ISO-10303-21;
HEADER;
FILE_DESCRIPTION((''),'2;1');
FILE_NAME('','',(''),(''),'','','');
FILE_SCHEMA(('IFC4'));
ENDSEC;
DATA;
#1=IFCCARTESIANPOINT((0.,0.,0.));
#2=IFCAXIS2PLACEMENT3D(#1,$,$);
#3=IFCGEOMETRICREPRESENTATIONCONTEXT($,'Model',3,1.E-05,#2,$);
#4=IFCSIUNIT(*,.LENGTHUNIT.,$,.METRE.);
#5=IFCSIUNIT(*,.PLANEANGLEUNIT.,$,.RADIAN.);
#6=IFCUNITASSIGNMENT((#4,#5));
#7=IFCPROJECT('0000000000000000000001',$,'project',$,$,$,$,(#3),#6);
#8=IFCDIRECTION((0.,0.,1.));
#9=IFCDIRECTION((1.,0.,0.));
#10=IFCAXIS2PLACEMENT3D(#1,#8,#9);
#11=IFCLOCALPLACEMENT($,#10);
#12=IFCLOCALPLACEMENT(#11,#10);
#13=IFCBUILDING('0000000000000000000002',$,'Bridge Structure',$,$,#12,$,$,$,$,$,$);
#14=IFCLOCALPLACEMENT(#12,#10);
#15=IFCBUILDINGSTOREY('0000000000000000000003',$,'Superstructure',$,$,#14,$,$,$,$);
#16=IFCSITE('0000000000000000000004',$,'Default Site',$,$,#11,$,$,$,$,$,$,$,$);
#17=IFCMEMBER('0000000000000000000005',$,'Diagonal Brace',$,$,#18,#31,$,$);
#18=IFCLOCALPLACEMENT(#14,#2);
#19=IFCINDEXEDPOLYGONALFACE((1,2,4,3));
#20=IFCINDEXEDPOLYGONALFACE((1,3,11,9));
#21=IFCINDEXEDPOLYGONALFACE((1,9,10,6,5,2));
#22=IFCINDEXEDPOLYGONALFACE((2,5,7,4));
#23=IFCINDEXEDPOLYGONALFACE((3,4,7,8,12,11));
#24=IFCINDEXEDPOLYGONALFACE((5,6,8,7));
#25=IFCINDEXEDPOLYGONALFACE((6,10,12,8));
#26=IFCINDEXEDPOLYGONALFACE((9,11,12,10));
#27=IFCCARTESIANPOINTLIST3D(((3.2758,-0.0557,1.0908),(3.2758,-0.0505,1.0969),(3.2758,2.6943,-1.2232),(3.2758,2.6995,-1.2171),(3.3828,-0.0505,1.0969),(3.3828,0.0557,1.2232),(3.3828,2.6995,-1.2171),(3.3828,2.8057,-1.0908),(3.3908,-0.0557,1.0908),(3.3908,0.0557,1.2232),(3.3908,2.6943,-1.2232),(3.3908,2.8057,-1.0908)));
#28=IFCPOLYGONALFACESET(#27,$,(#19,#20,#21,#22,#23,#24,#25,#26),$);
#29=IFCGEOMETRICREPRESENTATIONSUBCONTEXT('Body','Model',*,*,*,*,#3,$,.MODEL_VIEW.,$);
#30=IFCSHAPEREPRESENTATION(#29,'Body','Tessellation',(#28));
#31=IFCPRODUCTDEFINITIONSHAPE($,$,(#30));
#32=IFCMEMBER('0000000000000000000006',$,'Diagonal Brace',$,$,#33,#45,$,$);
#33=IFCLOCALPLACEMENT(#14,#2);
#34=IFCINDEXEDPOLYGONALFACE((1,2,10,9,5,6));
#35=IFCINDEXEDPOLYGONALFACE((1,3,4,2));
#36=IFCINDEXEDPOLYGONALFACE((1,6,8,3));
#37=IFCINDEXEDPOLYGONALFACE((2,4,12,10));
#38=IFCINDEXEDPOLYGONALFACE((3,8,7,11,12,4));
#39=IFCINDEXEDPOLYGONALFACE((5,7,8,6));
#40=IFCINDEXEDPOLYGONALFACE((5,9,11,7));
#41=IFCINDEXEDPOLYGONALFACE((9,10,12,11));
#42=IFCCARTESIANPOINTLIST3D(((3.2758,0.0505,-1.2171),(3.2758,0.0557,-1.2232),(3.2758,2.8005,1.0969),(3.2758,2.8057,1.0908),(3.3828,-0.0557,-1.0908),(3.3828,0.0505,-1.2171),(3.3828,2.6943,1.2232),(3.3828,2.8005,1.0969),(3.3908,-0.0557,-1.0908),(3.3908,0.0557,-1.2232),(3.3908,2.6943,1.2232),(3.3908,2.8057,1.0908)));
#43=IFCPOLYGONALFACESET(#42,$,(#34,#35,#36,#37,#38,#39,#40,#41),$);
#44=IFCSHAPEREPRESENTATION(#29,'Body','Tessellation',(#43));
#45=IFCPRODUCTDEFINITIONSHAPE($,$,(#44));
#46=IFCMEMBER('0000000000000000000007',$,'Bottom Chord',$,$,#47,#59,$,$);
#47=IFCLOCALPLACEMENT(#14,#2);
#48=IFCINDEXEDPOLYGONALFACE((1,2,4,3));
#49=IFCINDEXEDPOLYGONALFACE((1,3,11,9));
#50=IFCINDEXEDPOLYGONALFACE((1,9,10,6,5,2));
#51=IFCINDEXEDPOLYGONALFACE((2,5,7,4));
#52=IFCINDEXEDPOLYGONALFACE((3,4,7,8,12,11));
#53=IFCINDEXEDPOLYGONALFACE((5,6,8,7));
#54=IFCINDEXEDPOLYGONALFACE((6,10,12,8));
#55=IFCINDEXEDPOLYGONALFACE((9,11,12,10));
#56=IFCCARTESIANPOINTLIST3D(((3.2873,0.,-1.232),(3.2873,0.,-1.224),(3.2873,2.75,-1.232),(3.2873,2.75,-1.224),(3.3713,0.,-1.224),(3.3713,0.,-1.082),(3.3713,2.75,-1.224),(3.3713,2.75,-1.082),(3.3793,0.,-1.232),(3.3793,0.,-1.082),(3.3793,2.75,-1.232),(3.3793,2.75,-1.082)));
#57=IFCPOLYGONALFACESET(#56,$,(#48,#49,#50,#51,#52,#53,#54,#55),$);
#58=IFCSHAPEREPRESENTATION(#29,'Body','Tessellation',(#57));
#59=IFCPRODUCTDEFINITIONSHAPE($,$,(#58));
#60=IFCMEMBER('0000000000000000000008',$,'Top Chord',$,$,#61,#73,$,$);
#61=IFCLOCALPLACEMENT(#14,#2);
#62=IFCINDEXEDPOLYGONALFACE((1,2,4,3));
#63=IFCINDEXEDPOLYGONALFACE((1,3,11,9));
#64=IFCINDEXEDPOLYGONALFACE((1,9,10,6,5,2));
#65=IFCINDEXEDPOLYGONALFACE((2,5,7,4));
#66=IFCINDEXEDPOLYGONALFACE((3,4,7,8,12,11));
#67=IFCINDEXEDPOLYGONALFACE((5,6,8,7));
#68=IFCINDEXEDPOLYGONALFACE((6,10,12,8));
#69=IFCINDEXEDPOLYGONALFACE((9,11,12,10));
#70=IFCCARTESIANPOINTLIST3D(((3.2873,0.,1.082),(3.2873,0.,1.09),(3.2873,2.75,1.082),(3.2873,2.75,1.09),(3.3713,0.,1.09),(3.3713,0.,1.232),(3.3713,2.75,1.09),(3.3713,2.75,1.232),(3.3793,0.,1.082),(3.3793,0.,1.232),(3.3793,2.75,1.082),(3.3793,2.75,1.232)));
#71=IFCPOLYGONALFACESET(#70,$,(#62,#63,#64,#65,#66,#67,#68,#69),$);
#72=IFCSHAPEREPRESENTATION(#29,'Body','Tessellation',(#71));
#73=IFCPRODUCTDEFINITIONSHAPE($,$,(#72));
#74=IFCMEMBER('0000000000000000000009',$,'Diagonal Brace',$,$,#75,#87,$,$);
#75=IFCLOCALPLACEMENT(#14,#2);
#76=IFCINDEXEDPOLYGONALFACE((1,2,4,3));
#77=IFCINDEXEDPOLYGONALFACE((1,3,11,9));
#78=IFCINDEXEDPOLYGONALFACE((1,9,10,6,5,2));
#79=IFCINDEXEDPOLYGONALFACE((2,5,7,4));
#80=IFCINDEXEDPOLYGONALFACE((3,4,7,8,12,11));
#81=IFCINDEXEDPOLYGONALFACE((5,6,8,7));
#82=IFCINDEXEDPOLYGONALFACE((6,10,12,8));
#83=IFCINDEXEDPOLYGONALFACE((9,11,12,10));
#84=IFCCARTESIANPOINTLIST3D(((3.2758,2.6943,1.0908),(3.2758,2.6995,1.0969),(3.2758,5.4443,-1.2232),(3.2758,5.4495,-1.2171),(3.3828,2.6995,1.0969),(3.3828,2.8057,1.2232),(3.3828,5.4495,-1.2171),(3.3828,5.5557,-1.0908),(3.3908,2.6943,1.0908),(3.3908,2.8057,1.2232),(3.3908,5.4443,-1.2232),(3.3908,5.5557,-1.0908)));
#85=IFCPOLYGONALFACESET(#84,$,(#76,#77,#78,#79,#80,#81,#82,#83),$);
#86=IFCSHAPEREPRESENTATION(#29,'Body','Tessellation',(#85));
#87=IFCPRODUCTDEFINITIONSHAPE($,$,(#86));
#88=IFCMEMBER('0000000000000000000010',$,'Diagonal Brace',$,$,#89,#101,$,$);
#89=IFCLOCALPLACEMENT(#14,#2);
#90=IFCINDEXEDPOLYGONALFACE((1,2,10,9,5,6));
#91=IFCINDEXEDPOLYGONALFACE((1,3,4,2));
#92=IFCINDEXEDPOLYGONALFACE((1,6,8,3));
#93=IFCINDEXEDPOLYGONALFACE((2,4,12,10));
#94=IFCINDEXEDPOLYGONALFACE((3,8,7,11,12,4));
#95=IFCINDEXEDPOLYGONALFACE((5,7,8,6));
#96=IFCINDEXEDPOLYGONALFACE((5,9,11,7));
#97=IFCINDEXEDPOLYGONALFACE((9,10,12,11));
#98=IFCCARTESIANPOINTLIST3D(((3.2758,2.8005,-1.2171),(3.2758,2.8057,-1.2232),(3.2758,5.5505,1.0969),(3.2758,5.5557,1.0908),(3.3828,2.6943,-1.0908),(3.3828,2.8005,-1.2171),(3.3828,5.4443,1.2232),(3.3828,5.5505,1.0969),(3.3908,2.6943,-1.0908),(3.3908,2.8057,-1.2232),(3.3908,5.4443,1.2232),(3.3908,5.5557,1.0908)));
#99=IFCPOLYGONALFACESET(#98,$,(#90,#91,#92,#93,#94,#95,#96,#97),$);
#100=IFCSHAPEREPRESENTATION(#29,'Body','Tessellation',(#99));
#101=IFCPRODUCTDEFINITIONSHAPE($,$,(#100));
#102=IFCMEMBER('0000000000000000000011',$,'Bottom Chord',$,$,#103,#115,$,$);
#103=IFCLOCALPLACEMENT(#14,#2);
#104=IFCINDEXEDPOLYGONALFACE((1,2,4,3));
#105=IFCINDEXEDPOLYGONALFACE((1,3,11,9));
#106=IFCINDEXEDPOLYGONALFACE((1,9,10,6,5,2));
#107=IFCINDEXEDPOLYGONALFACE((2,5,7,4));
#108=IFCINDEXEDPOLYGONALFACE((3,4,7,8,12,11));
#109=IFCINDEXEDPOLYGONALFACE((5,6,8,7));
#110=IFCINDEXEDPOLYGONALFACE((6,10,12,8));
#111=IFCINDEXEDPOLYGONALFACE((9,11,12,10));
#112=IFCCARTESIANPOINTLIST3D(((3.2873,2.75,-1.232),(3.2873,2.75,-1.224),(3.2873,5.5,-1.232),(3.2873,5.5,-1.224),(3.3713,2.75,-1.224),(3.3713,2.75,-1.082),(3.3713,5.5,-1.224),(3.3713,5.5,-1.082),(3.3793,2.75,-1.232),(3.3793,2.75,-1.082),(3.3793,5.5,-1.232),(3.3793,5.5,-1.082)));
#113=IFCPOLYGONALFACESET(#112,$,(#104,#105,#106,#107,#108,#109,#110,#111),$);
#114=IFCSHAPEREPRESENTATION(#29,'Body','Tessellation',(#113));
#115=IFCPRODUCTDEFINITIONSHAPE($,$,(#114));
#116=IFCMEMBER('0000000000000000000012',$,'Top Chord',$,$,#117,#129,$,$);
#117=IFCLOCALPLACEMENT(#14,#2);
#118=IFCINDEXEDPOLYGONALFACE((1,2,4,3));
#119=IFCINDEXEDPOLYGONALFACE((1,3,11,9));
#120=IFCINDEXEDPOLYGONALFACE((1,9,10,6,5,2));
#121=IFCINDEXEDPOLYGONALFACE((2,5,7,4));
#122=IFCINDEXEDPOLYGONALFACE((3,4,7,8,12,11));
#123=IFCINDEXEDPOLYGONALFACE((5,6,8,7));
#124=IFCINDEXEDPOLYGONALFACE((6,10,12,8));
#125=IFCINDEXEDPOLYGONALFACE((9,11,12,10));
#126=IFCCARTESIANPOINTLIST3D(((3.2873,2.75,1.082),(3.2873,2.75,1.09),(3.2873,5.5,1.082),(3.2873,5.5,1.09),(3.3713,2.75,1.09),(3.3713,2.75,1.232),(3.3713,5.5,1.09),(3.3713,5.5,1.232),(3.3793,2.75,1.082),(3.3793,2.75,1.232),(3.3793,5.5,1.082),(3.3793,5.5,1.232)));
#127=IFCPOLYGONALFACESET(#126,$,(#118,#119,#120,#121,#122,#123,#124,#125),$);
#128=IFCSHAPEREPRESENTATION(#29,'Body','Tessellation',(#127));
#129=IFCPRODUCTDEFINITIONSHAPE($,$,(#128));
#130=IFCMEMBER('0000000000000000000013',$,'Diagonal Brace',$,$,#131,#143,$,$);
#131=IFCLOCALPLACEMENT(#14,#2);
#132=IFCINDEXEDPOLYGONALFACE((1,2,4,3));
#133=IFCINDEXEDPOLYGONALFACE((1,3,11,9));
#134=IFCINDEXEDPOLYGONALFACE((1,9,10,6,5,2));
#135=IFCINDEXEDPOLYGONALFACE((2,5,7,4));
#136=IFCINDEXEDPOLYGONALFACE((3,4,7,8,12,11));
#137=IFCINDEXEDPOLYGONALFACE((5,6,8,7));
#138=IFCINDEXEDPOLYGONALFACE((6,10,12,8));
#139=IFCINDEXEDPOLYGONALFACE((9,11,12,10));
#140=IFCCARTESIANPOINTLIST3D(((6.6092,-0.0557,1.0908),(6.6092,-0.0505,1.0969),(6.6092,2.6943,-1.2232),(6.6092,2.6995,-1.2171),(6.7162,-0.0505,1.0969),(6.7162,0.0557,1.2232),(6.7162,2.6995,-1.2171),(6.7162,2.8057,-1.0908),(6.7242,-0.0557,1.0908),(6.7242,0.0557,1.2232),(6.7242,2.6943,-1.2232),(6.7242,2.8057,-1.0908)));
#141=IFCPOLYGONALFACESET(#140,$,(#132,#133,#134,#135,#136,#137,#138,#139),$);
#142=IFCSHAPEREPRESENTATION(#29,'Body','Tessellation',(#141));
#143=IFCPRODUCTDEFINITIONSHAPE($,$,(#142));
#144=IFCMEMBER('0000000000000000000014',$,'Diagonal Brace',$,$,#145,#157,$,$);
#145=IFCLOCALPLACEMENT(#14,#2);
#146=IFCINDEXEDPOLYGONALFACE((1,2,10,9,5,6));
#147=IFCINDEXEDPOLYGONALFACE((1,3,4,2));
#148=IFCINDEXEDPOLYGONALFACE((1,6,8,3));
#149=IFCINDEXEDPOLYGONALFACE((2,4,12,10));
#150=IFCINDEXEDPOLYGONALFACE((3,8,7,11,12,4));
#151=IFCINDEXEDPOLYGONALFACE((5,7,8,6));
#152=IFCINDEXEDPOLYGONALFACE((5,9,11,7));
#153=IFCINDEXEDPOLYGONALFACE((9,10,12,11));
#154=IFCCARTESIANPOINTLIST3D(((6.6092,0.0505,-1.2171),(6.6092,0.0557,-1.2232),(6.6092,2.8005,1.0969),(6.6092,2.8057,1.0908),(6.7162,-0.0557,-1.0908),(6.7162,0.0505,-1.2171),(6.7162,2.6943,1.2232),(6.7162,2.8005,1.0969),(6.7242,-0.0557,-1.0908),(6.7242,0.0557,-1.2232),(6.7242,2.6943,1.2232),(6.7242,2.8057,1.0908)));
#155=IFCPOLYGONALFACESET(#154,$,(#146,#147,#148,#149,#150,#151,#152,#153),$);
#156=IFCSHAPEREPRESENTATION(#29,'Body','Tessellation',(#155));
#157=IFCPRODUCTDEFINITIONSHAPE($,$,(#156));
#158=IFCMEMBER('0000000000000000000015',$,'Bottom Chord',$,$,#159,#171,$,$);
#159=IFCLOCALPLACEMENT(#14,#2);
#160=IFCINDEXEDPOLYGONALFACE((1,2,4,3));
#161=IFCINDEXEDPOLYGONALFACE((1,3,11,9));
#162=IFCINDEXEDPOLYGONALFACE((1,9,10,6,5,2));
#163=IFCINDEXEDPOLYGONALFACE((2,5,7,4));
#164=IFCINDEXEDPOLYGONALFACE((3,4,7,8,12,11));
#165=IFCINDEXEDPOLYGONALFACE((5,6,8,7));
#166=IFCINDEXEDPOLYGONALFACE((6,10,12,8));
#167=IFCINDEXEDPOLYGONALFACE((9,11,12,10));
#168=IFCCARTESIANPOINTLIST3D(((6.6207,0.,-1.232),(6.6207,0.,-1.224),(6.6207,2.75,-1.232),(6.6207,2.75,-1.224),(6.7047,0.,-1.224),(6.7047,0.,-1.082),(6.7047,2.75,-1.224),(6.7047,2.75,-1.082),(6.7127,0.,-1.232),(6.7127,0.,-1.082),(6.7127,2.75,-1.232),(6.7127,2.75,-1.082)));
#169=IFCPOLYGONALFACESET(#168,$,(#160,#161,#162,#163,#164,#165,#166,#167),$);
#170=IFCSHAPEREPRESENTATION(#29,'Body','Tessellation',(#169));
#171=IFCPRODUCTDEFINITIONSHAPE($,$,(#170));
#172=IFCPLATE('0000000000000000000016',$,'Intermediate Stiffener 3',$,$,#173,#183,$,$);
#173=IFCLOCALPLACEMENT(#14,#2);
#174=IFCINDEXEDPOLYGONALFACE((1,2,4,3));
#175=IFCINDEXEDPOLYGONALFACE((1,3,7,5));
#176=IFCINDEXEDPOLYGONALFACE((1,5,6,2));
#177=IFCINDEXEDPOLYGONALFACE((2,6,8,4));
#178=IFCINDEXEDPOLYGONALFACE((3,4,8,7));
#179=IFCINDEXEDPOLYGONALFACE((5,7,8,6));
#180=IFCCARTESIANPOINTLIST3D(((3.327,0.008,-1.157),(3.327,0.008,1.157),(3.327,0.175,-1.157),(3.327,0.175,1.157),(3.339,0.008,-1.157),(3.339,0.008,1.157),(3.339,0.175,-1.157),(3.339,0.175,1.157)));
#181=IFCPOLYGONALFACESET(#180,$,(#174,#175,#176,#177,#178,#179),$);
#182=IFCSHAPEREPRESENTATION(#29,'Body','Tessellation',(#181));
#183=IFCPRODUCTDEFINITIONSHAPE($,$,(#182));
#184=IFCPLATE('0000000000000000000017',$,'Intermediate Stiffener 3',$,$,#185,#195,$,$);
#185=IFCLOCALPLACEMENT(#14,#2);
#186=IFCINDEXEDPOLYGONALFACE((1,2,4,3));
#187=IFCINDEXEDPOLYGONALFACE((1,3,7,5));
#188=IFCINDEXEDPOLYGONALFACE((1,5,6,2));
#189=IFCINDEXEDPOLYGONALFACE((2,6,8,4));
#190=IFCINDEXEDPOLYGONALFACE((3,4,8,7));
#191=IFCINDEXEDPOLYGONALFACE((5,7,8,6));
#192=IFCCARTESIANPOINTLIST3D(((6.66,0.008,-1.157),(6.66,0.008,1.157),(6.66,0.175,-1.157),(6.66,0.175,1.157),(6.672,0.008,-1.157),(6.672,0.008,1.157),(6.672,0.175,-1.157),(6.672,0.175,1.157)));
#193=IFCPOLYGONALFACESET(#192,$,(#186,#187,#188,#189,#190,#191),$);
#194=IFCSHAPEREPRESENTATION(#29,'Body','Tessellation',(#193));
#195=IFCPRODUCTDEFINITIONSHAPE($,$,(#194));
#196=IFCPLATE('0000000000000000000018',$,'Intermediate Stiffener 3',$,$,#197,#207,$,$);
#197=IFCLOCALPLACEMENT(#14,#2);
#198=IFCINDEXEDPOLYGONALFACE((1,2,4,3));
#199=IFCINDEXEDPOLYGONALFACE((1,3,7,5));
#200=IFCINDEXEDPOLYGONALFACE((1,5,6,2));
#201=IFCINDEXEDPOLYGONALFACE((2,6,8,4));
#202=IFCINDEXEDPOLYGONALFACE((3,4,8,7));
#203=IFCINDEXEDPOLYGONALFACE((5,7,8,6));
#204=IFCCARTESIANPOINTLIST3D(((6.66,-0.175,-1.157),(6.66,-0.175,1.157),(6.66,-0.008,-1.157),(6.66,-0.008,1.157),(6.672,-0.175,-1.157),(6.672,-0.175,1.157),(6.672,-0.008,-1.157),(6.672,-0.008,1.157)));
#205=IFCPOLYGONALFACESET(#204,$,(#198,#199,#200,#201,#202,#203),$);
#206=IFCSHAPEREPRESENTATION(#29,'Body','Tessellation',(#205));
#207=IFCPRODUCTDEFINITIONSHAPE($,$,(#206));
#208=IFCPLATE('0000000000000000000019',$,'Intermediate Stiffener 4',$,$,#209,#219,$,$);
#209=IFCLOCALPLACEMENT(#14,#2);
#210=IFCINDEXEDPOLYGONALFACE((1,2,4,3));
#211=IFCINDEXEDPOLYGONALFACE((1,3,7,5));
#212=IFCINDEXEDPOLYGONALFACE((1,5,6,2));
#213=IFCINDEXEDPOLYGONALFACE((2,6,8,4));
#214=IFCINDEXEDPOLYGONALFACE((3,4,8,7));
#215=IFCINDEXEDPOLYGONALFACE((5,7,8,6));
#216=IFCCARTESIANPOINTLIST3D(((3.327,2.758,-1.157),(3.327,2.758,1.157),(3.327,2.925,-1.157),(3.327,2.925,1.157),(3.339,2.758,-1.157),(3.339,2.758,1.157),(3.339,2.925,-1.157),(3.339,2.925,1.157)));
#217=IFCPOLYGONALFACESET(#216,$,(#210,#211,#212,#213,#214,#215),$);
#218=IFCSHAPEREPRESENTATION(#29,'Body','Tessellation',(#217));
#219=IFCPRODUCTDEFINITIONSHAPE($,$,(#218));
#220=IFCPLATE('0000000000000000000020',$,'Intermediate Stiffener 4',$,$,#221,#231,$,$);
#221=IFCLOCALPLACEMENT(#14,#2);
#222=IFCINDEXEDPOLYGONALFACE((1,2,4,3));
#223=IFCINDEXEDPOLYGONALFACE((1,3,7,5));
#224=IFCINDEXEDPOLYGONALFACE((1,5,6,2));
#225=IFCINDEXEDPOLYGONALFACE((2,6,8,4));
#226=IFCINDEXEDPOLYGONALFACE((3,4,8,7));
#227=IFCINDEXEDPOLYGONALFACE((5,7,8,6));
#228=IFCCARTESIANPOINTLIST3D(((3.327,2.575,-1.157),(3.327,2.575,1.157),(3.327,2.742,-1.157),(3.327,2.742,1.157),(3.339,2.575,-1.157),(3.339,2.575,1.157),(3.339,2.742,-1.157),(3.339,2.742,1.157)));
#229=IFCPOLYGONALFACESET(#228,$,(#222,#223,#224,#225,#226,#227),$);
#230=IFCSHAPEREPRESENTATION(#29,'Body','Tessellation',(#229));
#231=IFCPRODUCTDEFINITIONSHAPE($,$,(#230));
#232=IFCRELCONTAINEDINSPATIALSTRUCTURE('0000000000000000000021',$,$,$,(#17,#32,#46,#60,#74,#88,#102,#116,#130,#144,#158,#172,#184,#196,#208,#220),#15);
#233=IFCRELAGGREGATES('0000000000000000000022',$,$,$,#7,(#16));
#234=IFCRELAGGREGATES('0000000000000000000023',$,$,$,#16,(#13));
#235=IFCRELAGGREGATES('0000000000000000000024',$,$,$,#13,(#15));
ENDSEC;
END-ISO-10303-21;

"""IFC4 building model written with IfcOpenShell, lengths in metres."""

from ifc_helpers import new_model, si_unit, frame, origin, origin_with_axes, origin_2d_with_axis, place, context, subcontext, project, spatial, rectangle, l_section, extrude, element, save


model = new_model("IFC4")

# Units and contexts
model_context = context("Model", 3, precision=1e-05, world=origin())
body_context = subcontext(model_context, "Body", "Model", "MODEL_VIEW")
ifc_project = project(units=[si_unit("LENGTHUNIT", "METRE"), si_unit("PLANEANGLEUNIT", "RADIAN")], contexts=[model_context])

# Site, building, storey
site_placement = place(None, origin_with_axes())
site = spatial("IfcSite", under=ifc_project, at=site_placement, Name="Default Site")
building_placement = place(site_placement, origin_with_axes())
building = spatial("IfcBuilding", under=site, at=building_placement, Name="Bridge Structure")
storey_placement = place(building_placement, origin_with_axes())
storey = spatial("IfcBuildingStorey", under=building, at=storey_placement, Name="Superstructure")

# Members
for number, where, z_axis, x_axis, name in (
    (1, (3.3333, 0.0, 1.157), (0.0, 0.765156, -0.643844), (-1.0, 0.0, 0.0), "Diagonal Brace"),
    (2, (3.3333, 0.0, -1.157), (0.0, 0.765156, 0.643844), (-1.0, 0.0, 0.0), "Diagonal Brace"),
):
    element("IfcMember", number, at=place(storey_placement, frame(where, z_axis=z_axis, x_axis=x_axis)), inside=storey, Name=name, context=body_context, shape_type="SweptSolid", body=[
        extrude(l_section(Depth=0.173, Width=0.115, Thickness=0.008, at=origin_2d_with_axis()), origin_with_axes(), (0.0, 0.0, 1.0), 3.594),
    ])
for number, where, z_axis, x_axis, name in (
    (3, (3.3333, 0.0, -1.157), (0.0, 1.0, 0.0), (-1.0, 0.0, 0.0), "Bottom Chord"),
    (4, (3.3333, 0.0, 1.157), (0.0, 1.0, 0.0), (-1.0, 0.0, 0.0), "Top Chord"),
):
    element("IfcMember", number, at=place(storey_placement, frame(where, z_axis=z_axis, x_axis=x_axis)), inside=storey, Name=name, context=body_context, shape_type="SweptSolid", body=[
        extrude(l_section(Depth=0.15, Width=0.092, Thickness=0.008, at=origin_2d_with_axis()), origin_with_axes(), (0.0, 0.0, 1.0), 2.75),
    ])
for number, where, z_axis, x_axis, name in (
    (5, (3.3333, 2.75, 1.157), (0.0, 0.765156, -0.643844), (-1.0, 0.0, 0.0), "Diagonal Brace"),
    (6, (3.3333, 2.75, -1.157), (0.0, 0.765156, 0.643844), (-1.0, 0.0, 0.0), "Diagonal Brace"),
):
    element("IfcMember", number, at=place(storey_placement, frame(where, z_axis=z_axis, x_axis=x_axis)), inside=storey, Name=name, context=body_context, shape_type="SweptSolid", body=[
        extrude(l_section(Depth=0.173, Width=0.115, Thickness=0.008, at=origin_2d_with_axis()), origin_with_axes(), (0.0, 0.0, 1.0), 3.594),
    ])
for number, where, z_axis, x_axis, name in (
    (7, (3.3333, 2.75, -1.157), (0.0, 1.0, 0.0), (-1.0, 0.0, 0.0), "Bottom Chord"),
    (8, (3.3333, 2.75, 1.157), (0.0, 1.0, 0.0), (-1.0, 0.0, 0.0), "Top Chord"),
):
    element("IfcMember", number, at=place(storey_placement, frame(where, z_axis=z_axis, x_axis=x_axis)), inside=storey, Name=name, context=body_context, shape_type="SweptSolid", body=[
        extrude(l_section(Depth=0.15, Width=0.092, Thickness=0.008, at=origin_2d_with_axis()), origin_with_axes(), (0.0, 0.0, 1.0), 2.75),
    ])
for number, where, z_axis, x_axis, name in (
    (9, (6.6667, 0.0, 1.157), (0.0, 0.765156, -0.643844), (-1.0, 0.0, 0.0), "Diagonal Brace"),
    (10, (6.6667, 0.0, -1.157), (0.0, 0.765156, 0.643844), (-1.0, 0.0, 0.0), "Diagonal Brace"),
):
    element("IfcMember", number, at=place(storey_placement, frame(where, z_axis=z_axis, x_axis=x_axis)), inside=storey, Name=name, context=body_context, shape_type="SweptSolid", body=[
        extrude(l_section(Depth=0.173, Width=0.115, Thickness=0.008, at=origin_2d_with_axis()), origin_with_axes(), (0.0, 0.0, 1.0), 3.594),
    ])
member_placement = place(storey_placement, frame((6.6667, 0.0, -1.157), z_axis=(0.0, 1.0, 0.0), x_axis=(-1.0, 0.0, 0.0)))
element("IfcMember", 11, at=member_placement, inside=storey, Name="Bottom Chord", context=body_context, shape_type="SweptSolid", body=[
    extrude(l_section(Depth=0.15, Width=0.092, Thickness=0.008, at=origin_2d_with_axis()), origin_with_axes(), (0.0, 0.0, 1.0), 2.75),
])

# Plates
for number, where, z_axis, x_axis, name in (
    (12, (3.333, 0.0915, -1.157), (0.0, 0.0, 1.0), (1.0, 0.0, 0.0), "Intermediate Stiffener 3"),
    (13, (6.666, 0.0915, -1.157), (0.0, 0.0, 1.0), (1.0, 0.0, 0.0), "Intermediate Stiffener 3"),
    (14, (6.666, -0.0915, -1.157), (0.0, 0.0, 1.0), (1.0, 0.0, 0.0), "Intermediate Stiffener 3"),
    (15, (3.333, 2.8415, -1.157), (0.0, 0.0, 1.0), (1.0, 0.0, 0.0), "Intermediate Stiffener 4"),
    (16, (3.333, 2.6585, -1.157), (0.0, 0.0, 1.0), (1.0, 0.0, 0.0), "Intermediate Stiffener 4"),
):
    element("IfcPlate", number, at=place(storey_placement, frame(where, z_axis=z_axis, x_axis=x_axis)), inside=storey, Name=name, context=body_context, shape_type="SweptSolid", body=[
        extrude(rectangle(XDim=0.012, YDim=0.167, at=origin_2d_with_axis()), origin_with_axes(), (0.0, 0.0, 1.0), 2.314),
    ])

save(model, "model.ifc")
